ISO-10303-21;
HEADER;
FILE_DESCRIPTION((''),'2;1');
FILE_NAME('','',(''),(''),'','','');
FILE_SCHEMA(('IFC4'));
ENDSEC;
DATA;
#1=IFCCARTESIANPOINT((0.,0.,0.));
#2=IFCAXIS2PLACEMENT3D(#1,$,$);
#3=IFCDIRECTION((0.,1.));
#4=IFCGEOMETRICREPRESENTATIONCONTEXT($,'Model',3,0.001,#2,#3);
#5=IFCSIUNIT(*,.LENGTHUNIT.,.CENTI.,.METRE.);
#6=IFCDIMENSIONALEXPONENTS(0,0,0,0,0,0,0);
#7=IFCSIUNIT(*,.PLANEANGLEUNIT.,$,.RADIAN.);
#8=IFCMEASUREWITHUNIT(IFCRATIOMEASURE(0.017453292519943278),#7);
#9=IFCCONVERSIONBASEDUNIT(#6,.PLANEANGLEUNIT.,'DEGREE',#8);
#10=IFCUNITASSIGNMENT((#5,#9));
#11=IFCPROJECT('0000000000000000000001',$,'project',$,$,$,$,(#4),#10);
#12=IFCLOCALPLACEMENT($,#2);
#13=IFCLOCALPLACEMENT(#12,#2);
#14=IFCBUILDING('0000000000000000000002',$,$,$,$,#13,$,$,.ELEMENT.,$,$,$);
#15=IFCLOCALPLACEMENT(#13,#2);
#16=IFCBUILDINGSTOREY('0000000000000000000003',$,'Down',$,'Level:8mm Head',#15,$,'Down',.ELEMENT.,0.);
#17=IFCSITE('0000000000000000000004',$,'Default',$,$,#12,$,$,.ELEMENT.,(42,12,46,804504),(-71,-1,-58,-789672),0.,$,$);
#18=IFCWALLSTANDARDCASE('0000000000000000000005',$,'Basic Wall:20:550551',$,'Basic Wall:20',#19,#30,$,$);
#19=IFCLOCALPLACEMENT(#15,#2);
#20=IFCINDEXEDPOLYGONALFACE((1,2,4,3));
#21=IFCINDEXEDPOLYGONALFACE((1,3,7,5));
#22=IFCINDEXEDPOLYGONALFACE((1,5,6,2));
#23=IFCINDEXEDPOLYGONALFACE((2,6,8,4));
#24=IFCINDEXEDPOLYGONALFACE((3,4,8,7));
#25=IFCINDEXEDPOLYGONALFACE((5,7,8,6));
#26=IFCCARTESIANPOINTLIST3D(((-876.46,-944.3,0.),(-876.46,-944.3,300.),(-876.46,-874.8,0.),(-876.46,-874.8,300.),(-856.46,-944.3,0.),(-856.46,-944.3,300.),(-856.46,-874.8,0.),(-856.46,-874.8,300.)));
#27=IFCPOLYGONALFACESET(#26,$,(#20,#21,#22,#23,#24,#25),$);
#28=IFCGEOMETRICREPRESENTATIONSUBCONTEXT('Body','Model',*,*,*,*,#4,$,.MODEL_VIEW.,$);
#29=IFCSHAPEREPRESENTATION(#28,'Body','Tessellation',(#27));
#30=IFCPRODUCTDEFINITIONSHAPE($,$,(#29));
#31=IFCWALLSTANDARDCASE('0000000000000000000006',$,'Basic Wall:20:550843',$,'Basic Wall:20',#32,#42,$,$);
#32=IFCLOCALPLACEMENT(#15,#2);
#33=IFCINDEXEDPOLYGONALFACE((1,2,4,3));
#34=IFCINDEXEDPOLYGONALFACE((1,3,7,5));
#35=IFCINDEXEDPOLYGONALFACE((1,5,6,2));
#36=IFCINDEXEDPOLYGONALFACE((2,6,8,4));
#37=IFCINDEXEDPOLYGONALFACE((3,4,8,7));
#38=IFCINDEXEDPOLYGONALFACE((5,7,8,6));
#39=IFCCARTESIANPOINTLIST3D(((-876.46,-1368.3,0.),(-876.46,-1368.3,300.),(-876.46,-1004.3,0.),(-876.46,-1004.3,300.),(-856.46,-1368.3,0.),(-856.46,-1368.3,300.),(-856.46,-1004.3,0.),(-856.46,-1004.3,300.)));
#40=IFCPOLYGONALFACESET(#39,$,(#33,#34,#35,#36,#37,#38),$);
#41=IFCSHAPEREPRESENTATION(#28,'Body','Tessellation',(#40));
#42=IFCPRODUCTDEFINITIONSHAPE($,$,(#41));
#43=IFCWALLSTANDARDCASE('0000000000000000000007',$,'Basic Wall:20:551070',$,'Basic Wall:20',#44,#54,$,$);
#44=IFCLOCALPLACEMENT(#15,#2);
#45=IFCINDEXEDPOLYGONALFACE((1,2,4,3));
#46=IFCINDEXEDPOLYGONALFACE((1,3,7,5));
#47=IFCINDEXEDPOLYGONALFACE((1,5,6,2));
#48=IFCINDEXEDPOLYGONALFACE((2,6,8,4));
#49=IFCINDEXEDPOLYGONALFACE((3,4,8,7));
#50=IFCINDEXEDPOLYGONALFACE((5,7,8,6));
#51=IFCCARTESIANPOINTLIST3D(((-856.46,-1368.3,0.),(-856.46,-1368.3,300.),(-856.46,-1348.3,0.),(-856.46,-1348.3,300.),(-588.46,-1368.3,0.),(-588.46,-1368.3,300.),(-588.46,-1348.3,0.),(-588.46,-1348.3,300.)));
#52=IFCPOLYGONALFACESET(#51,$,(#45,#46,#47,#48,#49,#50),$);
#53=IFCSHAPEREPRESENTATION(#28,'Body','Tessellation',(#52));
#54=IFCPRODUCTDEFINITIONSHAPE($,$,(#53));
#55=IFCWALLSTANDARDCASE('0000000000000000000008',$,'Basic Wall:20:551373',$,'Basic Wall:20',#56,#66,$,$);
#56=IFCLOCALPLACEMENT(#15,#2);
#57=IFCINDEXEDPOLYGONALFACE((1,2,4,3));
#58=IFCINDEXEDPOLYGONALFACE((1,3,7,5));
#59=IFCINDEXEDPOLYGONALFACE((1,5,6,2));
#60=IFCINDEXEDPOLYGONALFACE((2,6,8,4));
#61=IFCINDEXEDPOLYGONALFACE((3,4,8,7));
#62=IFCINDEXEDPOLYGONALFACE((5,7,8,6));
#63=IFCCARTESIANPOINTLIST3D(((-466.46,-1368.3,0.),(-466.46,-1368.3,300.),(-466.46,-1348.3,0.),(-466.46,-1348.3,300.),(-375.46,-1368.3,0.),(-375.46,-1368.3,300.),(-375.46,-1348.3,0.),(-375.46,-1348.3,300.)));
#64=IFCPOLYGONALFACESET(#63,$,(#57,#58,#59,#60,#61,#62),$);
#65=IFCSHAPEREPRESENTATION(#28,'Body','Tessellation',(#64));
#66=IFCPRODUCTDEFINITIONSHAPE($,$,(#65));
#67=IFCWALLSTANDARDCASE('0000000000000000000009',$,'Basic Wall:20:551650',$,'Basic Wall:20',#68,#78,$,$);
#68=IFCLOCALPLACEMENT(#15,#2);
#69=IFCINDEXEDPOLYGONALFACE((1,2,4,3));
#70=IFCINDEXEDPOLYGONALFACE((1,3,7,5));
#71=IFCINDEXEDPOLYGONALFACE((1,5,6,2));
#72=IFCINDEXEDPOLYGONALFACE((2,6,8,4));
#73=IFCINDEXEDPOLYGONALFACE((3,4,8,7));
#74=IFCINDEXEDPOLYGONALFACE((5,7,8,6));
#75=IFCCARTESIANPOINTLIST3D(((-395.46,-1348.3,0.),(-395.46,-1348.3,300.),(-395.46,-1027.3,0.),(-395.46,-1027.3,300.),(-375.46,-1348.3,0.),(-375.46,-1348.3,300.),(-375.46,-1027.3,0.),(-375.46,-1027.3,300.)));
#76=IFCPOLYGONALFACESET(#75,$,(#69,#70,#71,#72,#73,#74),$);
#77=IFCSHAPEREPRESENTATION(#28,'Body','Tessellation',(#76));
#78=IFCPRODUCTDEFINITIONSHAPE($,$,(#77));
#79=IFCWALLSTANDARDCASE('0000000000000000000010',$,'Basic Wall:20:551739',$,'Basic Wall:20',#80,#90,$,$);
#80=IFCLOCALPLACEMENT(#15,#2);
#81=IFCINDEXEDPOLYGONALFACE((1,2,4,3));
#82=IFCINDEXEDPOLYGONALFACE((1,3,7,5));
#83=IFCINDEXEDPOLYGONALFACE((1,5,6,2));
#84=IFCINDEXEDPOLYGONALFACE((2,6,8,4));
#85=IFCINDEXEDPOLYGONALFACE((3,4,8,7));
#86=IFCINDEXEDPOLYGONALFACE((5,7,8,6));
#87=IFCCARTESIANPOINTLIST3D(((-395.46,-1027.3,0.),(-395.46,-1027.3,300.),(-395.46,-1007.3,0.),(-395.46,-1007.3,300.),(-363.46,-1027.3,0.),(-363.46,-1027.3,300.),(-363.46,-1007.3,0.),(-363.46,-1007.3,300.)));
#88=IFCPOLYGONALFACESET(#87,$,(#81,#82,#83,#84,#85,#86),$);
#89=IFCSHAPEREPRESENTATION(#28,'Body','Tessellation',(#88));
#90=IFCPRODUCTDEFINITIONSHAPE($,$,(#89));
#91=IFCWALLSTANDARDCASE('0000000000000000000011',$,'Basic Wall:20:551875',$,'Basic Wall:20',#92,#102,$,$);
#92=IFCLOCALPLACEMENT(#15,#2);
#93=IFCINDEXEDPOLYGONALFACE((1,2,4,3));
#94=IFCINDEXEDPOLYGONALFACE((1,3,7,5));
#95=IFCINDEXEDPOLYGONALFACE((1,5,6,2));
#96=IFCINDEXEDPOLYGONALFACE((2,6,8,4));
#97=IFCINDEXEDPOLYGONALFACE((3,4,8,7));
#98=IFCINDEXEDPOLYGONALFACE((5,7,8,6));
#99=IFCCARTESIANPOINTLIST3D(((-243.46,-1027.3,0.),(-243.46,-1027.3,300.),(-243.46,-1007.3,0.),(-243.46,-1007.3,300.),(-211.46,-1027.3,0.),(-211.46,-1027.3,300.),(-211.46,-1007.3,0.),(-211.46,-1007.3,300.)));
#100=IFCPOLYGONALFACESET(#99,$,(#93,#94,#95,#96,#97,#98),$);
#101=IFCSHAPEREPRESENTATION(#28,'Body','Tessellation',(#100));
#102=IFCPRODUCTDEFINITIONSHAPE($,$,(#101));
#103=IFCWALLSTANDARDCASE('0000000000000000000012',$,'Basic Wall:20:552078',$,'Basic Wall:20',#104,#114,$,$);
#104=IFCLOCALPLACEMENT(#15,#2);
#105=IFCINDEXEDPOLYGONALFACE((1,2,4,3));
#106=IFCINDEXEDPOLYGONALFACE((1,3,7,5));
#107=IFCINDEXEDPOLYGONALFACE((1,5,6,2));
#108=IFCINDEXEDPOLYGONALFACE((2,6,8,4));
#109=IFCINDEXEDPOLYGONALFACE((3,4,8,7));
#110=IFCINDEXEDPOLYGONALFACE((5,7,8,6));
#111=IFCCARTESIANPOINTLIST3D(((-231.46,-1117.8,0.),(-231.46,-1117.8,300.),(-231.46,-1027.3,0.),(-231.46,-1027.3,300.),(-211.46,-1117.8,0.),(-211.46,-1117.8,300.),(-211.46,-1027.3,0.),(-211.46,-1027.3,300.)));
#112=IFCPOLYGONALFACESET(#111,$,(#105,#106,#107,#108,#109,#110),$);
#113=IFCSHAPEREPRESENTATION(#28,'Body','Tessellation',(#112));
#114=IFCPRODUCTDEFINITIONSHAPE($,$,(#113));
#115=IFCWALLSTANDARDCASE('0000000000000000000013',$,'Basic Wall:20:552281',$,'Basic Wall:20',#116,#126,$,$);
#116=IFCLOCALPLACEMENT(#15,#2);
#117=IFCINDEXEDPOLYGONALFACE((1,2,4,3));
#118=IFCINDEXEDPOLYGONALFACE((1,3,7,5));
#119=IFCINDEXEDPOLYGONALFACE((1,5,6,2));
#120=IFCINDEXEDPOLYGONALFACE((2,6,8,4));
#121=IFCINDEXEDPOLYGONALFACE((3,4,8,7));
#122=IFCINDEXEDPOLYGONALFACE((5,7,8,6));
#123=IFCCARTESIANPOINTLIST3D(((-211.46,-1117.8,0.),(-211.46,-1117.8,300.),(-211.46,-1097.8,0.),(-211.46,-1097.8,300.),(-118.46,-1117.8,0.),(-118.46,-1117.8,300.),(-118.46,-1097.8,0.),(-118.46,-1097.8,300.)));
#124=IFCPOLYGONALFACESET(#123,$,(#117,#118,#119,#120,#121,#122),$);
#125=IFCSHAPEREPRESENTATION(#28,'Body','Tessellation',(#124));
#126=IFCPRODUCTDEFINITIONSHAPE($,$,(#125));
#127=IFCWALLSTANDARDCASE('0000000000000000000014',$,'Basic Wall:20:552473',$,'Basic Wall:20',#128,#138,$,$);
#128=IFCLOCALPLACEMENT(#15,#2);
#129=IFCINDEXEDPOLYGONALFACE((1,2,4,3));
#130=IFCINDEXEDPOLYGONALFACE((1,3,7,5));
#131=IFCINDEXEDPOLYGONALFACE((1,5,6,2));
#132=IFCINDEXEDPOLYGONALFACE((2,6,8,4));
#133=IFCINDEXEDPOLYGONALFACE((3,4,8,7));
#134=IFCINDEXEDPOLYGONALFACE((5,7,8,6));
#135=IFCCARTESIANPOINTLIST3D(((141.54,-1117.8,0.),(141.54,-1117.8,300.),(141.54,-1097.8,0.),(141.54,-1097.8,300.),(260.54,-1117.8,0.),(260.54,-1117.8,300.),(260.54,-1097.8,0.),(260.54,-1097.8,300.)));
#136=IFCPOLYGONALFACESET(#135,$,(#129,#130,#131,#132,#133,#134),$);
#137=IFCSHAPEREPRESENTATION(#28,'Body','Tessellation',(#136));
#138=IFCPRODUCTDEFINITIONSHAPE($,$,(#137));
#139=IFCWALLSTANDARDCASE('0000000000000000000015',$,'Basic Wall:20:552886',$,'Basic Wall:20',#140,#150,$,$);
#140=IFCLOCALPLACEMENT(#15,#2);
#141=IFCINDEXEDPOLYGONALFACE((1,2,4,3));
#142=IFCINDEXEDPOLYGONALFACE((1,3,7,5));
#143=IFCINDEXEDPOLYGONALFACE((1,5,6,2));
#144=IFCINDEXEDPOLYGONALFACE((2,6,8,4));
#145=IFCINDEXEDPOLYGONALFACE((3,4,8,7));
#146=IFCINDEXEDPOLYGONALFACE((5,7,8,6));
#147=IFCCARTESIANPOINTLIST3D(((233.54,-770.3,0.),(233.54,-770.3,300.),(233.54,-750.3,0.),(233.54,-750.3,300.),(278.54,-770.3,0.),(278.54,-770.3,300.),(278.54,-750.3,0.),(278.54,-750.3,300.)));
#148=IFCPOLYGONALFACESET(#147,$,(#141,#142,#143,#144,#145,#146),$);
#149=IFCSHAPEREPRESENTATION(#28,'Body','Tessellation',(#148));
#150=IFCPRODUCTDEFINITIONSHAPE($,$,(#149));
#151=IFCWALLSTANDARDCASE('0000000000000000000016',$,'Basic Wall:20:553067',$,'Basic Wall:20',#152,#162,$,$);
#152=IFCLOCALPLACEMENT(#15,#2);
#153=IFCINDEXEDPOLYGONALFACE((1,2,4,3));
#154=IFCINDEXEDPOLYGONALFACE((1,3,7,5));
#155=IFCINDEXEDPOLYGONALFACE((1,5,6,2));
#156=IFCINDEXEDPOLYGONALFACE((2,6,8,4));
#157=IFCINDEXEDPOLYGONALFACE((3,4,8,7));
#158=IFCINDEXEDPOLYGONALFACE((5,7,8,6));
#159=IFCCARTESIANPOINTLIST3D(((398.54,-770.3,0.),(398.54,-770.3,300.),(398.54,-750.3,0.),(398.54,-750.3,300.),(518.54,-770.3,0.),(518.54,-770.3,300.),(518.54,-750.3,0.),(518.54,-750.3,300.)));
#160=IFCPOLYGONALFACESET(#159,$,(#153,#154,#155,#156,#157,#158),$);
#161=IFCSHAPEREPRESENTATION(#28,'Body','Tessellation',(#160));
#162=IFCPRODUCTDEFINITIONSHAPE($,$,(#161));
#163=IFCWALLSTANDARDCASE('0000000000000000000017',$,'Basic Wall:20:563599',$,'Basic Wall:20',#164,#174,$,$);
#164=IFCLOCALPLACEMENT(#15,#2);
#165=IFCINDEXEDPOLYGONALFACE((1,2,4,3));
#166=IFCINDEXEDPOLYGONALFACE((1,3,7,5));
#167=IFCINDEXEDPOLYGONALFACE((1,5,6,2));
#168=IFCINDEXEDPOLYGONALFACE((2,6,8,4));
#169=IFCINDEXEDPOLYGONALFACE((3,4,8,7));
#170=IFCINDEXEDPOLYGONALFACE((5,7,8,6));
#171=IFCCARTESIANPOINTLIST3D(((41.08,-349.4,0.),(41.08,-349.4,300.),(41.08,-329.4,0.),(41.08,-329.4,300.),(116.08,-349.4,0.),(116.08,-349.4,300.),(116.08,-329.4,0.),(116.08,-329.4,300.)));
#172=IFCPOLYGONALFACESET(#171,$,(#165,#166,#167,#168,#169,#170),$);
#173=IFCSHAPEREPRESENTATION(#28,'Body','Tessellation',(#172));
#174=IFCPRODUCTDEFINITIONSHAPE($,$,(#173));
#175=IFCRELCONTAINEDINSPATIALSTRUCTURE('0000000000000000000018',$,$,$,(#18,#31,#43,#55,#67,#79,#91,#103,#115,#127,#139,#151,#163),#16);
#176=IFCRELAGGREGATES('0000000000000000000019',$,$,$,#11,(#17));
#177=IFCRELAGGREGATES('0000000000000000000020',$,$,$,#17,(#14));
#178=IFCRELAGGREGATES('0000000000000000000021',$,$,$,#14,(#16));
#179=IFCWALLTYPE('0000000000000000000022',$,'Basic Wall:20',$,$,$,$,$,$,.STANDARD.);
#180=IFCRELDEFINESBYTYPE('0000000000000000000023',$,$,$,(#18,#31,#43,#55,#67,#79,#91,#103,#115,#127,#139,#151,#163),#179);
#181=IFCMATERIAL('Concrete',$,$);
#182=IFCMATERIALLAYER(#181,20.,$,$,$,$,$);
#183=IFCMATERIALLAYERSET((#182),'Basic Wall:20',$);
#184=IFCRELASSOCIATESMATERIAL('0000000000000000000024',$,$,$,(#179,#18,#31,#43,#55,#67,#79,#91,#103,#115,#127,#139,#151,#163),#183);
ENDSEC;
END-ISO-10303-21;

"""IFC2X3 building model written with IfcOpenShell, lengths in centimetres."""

from ifc_helpers import new_model, entity, si_unit, converted_unit, direction, frame, frame_2d, origin, place, context, subcontext, project, spatial, rectangle, extrude, material, layer, layer_set, layer_usage, type_object, element, save


model = new_model("IFC2X3")

# Units and contexts
model_context = context("Model", 3, precision=0.001, world=origin(), true_north=direction((0.0, 1.0)))
body_context = subcontext(model_context, "Body", "Model", "MODEL_VIEW")
ifc_project = project(units=[si_unit("LENGTHUNIT", "METRE", prefix="CENTI"), converted_unit("PLANEANGLEUNIT", "DEGREE", entity("IfcRatioMeasure", 0.017453292519943278), si_unit("PLANEANGLEUNIT", "RADIAN"), dimensions=[0, 0, 0, 0, 0, 0, 0])], contexts=[model_context])

# Site, building, storey
site_placement = place(None, origin())
site = spatial("IfcSite", under=ifc_project, at=site_placement, Name="Default", CompositionType="ELEMENT", RefLatitude=(42, 12, 46, 804504), RefLongitude=(-71, -1, -58, -789672), RefElevation=0.0)
building_placement = place(site_placement, origin())
building = spatial("IfcBuilding", under=site, at=building_placement, CompositionType="ELEMENT")
storey_placement = place(building_placement, origin())
storey = spatial("IfcBuildingStorey", under=building, at=storey_placement, Name="Down", ObjectType="Level:8mm Head", LongName="Down", CompositionType="ELEMENT", Elevation=0.0)

# Walls
ifc_material = material(Name="Concrete")
ifc_layer_1 = layer(ifc_material, 20.0)
ifc_layer_set_1 = layer_set([ifc_layer_1], Name="Basic Wall:20")
wall_type_1 = type_object("IfcWallType", Name="Basic Wall:20", PredefinedType="STANDARD", material=ifc_layer_set_1)
ifc_layer_usage_1 = layer_usage(ifc_layer_set_1, "AXIS2", "NEGATIVE", 10.0)
wall_1_placement = place(storey_placement, frame((-866.46, -874.8, 0.0), z_axis=(0.0, 0.0, 1.0), x_axis=(0.0, -1.0, 0.0)))
element("IfcWallStandardCase", 1, at=wall_1_placement, inside=storey, type_object=wall_type_1, material=ifc_layer_usage_1, Name="Basic Wall:20:550551", ObjectType="Basic Wall:20", context=body_context, shape_type="SweptSolid", body=[
    extrude(rectangle(XDim=69.5, YDim=20.0, at=frame_2d((34.75, 0.0), x_axis=(-1.0, 0.0))), origin(), (0.0, 0.0, 1.0), 300.0),
])
ifc_layer_usage_2 = layer_usage(ifc_layer_set_1, "AXIS2", "NEGATIVE", 10.0)
wall_2_placement = place(storey_placement, frame((-866.46, -1004.3, 0.0), z_axis=(0.0, 0.0, 1.0), x_axis=(0.0, -1.0, 0.0)))
element("IfcWallStandardCase", 2, at=wall_2_placement, inside=storey, type_object=wall_type_1, material=ifc_layer_usage_2, Name="Basic Wall:20:550843", ObjectType="Basic Wall:20", context=body_context, shape_type="SweptSolid", body=[
    extrude(rectangle(XDim=364.0, YDim=20.0, at=frame_2d((182.0, 0.0), x_axis=(-1.0, 0.0))), origin(), (0.0, 0.0, 1.0), 300.0),
])
ifc_layer_usage_3 = layer_usage(ifc_layer_set_1, "AXIS2", "POSITIVE", -10.0)
wall_3_placement = place(storey_placement, frame((-856.46, -1358.3, 0.0)))
element("IfcWallStandardCase", 3, at=wall_3_placement, inside=storey, type_object=wall_type_1, material=ifc_layer_usage_3, Name="Basic Wall:20:551070", ObjectType="Basic Wall:20", context=body_context, shape_type="SweptSolid", body=[
    extrude(rectangle(XDim=268.0, YDim=20.0, at=frame_2d((134.0, 0.0), x_axis=(-1.0, 0.0))), origin(), (0.0, 0.0, 1.0), 300.0),
])
ifc_layer_usage_4 = layer_usage(ifc_layer_set_1, "AXIS2", "POSITIVE", -10.0)
wall_4_placement = place(storey_placement, frame((-466.46, -1358.3, 0.0)))
element("IfcWallStandardCase", 4, at=wall_4_placement, inside=storey, type_object=wall_type_1, material=ifc_layer_usage_4, Name="Basic Wall:20:551373", ObjectType="Basic Wall:20", context=body_context, shape_type="SweptSolid", body=[
    extrude(rectangle(XDim=91.0, YDim=20.0, at=frame_2d((45.5, 0.0), x_axis=(-1.0, 0.0))), origin(), (0.0, 0.0, 1.0), 300.0),
])
ifc_layer_usage_5 = layer_usage(ifc_layer_set_1, "AXIS2", "POSITIVE", -10.0)
wall_5_placement = place(storey_placement, frame((-385.46, -1348.3, 0.0), z_axis=(0.0, 0.0, 1.0), x_axis=(0.0, 1.0, 0.0)))
element("IfcWallStandardCase", 5, at=wall_5_placement, inside=storey, type_object=wall_type_1, material=ifc_layer_usage_5, Name="Basic Wall:20:551650", ObjectType="Basic Wall:20", context=body_context, shape_type="SweptSolid", body=[
    extrude(rectangle(XDim=321.0, YDim=20.0, at=frame_2d((160.5, 0.0), x_axis=(-1.0, 0.0))), origin(), (0.0, 0.0, 1.0), 300.0),
])
ifc_layer_usage_6 = layer_usage(ifc_layer_set_1, "AXIS2", "NEGATIVE", 10.0)
wall_6_placement = place(storey_placement, frame((-395.46, -1017.3, 0.0)))
element("IfcWallStandardCase", 6, at=wall_6_placement, inside=storey, type_object=wall_type_1, material=ifc_layer_usage_6, Name="Basic Wall:20:551739", ObjectType="Basic Wall:20", context=body_context, shape_type="SweptSolid", body=[
    extrude(rectangle(XDim=32.0, YDim=20.0, at=frame_2d((16.0, 0.0), x_axis=(-1.0, 0.0))), origin(), (0.0, 0.0, 1.0), 300.0),
])
ifc_layer_usage_7 = layer_usage(ifc_layer_set_1, "AXIS2", "NEGATIVE", 10.0)
wall_7_placement = place(storey_placement, frame((-243.46, -1017.3, 0.0)))
element("IfcWallStandardCase", 7, at=wall_7_placement, inside=storey, type_object=wall_type_1, material=ifc_layer_usage_7, Name="Basic Wall:20:551875", ObjectType="Basic Wall:20", context=body_context, shape_type="SweptSolid", body=[
    extrude(rectangle(XDim=32.0, YDim=20.0, at=frame_2d((16.0, 0.0), x_axis=(-1.0, 0.0))), origin(), (0.0, 0.0, 1.0), 300.0),
])
ifc_layer_usage_8 = layer_usage(ifc_layer_set_1, "AXIS2", "NEGATIVE", 10.0)
wall_8_placement = place(storey_placement, frame((-221.46, -1027.3, 0.0), z_axis=(0.0, 0.0, 1.0), x_axis=(0.0, -1.0, 0.0)))
element("IfcWallStandardCase", 8, at=wall_8_placement, inside=storey, type_object=wall_type_1, material=ifc_layer_usage_8, Name="Basic Wall:20:552078", ObjectType="Basic Wall:20", context=body_context, shape_type="SweptSolid", body=[
    extrude(rectangle(XDim=90.5, YDim=20.0, at=frame_2d((45.25, 0.0), x_axis=(-1.0, 0.0))), origin(), (0.0, 0.0, 1.0), 300.0),
])
ifc_layer_usage_9 = layer_usage(ifc_layer_set_1, "AXIS2", "POSITIVE", -10.0)
wall_9_placement = place(storey_placement, frame((-211.46, -1107.8, 0.0)))
element("IfcWallStandardCase", 9, at=wall_9_placement, inside=storey, type_object=wall_type_1, material=ifc_layer_usage_9, Name="Basic Wall:20:552281", ObjectType="Basic Wall:20", context=body_context, shape_type="SweptSolid", body=[
    extrude(rectangle(XDim=93.0, YDim=20.0, at=frame_2d((46.5, 0.0), x_axis=(-1.0, 0.0))), origin(), (0.0, 0.0, 1.0), 300.0),
])
ifc_layer_usage_10 = layer_usage(ifc_layer_set_1, "AXIS2", "POSITIVE", -10.0)
wall_10_placement = place(storey_placement, frame((141.54, -1107.8, 0.0)))
element("IfcWallStandardCase", 10, at=wall_10_placement, inside=storey, type_object=wall_type_1, material=ifc_layer_usage_10, Name="Basic Wall:20:552473", ObjectType="Basic Wall:20", context=body_context, shape_type="SweptSolid", body=[
    extrude(rectangle(XDim=119.0, YDim=20.0, at=frame_2d((59.5, 0.0), x_axis=(-1.0, 0.0))), origin(), (0.0, 0.0, 1.0), 300.0),
])
ifc_layer_usage_11 = layer_usage(ifc_layer_set_1, "AXIS2", "NEGATIVE", 10.0)
wall_11_placement = place(storey_placement, frame((233.54, -760.3, 0.0)))
element("IfcWallStandardCase", 11, at=wall_11_placement, inside=storey, type_object=wall_type_1, material=ifc_layer_usage_11, Name="Basic Wall:20:552886", ObjectType="Basic Wall:20", context=body_context, shape_type="SweptSolid", body=[
    extrude(rectangle(XDim=45.0, YDim=20.0, at=frame_2d((22.5, 0.0), x_axis=(-1.0, 0.0))), origin(), (0.0, 0.0, 1.0), 300.0),
])
ifc_layer_usage_12 = layer_usage(ifc_layer_set_1, "AXIS2", "NEGATIVE", 10.0)
wall_12_placement = place(storey_placement, frame((398.54, -760.3, 0.0)))
element("IfcWallStandardCase", 12, at=wall_12_placement, inside=storey, type_object=wall_type_1, material=ifc_layer_usage_12, Name="Basic Wall:20:553067", ObjectType="Basic Wall:20", context=body_context, shape_type="SweptSolid", body=[
    extrude(rectangle(XDim=120.0, YDim=20.0, at=frame_2d((60.0, 0.0), x_axis=(-1.0, 0.0))), origin(), (0.0, 0.0, 1.0), 300.0),
])
ifc_layer_usage_13 = layer_usage(ifc_layer_set_1, "AXIS2", "NEGATIVE", 10.0)
wall_13_placement = place(storey_placement, frame((116.08, -339.4, 0.0), z_axis=(0.0, 0.0, 1.0), x_axis=(-1.0, 0.0, 0.0)))
element("IfcWallStandardCase", 13, at=wall_13_placement, inside=storey, type_object=wall_type_1, material=ifc_layer_usage_13, Name="Basic Wall:20:563599", ObjectType="Basic Wall:20", context=body_context, shape_type="SweptSolid", body=[
    extrude(rectangle(XDim=75.0, YDim=20.0, at=frame_2d((37.5, 0.0), x_axis=(-1.0, 0.0))), origin(), (0.0, 0.0, 1.0), 300.0),
])

save(model, "model.ifc")
